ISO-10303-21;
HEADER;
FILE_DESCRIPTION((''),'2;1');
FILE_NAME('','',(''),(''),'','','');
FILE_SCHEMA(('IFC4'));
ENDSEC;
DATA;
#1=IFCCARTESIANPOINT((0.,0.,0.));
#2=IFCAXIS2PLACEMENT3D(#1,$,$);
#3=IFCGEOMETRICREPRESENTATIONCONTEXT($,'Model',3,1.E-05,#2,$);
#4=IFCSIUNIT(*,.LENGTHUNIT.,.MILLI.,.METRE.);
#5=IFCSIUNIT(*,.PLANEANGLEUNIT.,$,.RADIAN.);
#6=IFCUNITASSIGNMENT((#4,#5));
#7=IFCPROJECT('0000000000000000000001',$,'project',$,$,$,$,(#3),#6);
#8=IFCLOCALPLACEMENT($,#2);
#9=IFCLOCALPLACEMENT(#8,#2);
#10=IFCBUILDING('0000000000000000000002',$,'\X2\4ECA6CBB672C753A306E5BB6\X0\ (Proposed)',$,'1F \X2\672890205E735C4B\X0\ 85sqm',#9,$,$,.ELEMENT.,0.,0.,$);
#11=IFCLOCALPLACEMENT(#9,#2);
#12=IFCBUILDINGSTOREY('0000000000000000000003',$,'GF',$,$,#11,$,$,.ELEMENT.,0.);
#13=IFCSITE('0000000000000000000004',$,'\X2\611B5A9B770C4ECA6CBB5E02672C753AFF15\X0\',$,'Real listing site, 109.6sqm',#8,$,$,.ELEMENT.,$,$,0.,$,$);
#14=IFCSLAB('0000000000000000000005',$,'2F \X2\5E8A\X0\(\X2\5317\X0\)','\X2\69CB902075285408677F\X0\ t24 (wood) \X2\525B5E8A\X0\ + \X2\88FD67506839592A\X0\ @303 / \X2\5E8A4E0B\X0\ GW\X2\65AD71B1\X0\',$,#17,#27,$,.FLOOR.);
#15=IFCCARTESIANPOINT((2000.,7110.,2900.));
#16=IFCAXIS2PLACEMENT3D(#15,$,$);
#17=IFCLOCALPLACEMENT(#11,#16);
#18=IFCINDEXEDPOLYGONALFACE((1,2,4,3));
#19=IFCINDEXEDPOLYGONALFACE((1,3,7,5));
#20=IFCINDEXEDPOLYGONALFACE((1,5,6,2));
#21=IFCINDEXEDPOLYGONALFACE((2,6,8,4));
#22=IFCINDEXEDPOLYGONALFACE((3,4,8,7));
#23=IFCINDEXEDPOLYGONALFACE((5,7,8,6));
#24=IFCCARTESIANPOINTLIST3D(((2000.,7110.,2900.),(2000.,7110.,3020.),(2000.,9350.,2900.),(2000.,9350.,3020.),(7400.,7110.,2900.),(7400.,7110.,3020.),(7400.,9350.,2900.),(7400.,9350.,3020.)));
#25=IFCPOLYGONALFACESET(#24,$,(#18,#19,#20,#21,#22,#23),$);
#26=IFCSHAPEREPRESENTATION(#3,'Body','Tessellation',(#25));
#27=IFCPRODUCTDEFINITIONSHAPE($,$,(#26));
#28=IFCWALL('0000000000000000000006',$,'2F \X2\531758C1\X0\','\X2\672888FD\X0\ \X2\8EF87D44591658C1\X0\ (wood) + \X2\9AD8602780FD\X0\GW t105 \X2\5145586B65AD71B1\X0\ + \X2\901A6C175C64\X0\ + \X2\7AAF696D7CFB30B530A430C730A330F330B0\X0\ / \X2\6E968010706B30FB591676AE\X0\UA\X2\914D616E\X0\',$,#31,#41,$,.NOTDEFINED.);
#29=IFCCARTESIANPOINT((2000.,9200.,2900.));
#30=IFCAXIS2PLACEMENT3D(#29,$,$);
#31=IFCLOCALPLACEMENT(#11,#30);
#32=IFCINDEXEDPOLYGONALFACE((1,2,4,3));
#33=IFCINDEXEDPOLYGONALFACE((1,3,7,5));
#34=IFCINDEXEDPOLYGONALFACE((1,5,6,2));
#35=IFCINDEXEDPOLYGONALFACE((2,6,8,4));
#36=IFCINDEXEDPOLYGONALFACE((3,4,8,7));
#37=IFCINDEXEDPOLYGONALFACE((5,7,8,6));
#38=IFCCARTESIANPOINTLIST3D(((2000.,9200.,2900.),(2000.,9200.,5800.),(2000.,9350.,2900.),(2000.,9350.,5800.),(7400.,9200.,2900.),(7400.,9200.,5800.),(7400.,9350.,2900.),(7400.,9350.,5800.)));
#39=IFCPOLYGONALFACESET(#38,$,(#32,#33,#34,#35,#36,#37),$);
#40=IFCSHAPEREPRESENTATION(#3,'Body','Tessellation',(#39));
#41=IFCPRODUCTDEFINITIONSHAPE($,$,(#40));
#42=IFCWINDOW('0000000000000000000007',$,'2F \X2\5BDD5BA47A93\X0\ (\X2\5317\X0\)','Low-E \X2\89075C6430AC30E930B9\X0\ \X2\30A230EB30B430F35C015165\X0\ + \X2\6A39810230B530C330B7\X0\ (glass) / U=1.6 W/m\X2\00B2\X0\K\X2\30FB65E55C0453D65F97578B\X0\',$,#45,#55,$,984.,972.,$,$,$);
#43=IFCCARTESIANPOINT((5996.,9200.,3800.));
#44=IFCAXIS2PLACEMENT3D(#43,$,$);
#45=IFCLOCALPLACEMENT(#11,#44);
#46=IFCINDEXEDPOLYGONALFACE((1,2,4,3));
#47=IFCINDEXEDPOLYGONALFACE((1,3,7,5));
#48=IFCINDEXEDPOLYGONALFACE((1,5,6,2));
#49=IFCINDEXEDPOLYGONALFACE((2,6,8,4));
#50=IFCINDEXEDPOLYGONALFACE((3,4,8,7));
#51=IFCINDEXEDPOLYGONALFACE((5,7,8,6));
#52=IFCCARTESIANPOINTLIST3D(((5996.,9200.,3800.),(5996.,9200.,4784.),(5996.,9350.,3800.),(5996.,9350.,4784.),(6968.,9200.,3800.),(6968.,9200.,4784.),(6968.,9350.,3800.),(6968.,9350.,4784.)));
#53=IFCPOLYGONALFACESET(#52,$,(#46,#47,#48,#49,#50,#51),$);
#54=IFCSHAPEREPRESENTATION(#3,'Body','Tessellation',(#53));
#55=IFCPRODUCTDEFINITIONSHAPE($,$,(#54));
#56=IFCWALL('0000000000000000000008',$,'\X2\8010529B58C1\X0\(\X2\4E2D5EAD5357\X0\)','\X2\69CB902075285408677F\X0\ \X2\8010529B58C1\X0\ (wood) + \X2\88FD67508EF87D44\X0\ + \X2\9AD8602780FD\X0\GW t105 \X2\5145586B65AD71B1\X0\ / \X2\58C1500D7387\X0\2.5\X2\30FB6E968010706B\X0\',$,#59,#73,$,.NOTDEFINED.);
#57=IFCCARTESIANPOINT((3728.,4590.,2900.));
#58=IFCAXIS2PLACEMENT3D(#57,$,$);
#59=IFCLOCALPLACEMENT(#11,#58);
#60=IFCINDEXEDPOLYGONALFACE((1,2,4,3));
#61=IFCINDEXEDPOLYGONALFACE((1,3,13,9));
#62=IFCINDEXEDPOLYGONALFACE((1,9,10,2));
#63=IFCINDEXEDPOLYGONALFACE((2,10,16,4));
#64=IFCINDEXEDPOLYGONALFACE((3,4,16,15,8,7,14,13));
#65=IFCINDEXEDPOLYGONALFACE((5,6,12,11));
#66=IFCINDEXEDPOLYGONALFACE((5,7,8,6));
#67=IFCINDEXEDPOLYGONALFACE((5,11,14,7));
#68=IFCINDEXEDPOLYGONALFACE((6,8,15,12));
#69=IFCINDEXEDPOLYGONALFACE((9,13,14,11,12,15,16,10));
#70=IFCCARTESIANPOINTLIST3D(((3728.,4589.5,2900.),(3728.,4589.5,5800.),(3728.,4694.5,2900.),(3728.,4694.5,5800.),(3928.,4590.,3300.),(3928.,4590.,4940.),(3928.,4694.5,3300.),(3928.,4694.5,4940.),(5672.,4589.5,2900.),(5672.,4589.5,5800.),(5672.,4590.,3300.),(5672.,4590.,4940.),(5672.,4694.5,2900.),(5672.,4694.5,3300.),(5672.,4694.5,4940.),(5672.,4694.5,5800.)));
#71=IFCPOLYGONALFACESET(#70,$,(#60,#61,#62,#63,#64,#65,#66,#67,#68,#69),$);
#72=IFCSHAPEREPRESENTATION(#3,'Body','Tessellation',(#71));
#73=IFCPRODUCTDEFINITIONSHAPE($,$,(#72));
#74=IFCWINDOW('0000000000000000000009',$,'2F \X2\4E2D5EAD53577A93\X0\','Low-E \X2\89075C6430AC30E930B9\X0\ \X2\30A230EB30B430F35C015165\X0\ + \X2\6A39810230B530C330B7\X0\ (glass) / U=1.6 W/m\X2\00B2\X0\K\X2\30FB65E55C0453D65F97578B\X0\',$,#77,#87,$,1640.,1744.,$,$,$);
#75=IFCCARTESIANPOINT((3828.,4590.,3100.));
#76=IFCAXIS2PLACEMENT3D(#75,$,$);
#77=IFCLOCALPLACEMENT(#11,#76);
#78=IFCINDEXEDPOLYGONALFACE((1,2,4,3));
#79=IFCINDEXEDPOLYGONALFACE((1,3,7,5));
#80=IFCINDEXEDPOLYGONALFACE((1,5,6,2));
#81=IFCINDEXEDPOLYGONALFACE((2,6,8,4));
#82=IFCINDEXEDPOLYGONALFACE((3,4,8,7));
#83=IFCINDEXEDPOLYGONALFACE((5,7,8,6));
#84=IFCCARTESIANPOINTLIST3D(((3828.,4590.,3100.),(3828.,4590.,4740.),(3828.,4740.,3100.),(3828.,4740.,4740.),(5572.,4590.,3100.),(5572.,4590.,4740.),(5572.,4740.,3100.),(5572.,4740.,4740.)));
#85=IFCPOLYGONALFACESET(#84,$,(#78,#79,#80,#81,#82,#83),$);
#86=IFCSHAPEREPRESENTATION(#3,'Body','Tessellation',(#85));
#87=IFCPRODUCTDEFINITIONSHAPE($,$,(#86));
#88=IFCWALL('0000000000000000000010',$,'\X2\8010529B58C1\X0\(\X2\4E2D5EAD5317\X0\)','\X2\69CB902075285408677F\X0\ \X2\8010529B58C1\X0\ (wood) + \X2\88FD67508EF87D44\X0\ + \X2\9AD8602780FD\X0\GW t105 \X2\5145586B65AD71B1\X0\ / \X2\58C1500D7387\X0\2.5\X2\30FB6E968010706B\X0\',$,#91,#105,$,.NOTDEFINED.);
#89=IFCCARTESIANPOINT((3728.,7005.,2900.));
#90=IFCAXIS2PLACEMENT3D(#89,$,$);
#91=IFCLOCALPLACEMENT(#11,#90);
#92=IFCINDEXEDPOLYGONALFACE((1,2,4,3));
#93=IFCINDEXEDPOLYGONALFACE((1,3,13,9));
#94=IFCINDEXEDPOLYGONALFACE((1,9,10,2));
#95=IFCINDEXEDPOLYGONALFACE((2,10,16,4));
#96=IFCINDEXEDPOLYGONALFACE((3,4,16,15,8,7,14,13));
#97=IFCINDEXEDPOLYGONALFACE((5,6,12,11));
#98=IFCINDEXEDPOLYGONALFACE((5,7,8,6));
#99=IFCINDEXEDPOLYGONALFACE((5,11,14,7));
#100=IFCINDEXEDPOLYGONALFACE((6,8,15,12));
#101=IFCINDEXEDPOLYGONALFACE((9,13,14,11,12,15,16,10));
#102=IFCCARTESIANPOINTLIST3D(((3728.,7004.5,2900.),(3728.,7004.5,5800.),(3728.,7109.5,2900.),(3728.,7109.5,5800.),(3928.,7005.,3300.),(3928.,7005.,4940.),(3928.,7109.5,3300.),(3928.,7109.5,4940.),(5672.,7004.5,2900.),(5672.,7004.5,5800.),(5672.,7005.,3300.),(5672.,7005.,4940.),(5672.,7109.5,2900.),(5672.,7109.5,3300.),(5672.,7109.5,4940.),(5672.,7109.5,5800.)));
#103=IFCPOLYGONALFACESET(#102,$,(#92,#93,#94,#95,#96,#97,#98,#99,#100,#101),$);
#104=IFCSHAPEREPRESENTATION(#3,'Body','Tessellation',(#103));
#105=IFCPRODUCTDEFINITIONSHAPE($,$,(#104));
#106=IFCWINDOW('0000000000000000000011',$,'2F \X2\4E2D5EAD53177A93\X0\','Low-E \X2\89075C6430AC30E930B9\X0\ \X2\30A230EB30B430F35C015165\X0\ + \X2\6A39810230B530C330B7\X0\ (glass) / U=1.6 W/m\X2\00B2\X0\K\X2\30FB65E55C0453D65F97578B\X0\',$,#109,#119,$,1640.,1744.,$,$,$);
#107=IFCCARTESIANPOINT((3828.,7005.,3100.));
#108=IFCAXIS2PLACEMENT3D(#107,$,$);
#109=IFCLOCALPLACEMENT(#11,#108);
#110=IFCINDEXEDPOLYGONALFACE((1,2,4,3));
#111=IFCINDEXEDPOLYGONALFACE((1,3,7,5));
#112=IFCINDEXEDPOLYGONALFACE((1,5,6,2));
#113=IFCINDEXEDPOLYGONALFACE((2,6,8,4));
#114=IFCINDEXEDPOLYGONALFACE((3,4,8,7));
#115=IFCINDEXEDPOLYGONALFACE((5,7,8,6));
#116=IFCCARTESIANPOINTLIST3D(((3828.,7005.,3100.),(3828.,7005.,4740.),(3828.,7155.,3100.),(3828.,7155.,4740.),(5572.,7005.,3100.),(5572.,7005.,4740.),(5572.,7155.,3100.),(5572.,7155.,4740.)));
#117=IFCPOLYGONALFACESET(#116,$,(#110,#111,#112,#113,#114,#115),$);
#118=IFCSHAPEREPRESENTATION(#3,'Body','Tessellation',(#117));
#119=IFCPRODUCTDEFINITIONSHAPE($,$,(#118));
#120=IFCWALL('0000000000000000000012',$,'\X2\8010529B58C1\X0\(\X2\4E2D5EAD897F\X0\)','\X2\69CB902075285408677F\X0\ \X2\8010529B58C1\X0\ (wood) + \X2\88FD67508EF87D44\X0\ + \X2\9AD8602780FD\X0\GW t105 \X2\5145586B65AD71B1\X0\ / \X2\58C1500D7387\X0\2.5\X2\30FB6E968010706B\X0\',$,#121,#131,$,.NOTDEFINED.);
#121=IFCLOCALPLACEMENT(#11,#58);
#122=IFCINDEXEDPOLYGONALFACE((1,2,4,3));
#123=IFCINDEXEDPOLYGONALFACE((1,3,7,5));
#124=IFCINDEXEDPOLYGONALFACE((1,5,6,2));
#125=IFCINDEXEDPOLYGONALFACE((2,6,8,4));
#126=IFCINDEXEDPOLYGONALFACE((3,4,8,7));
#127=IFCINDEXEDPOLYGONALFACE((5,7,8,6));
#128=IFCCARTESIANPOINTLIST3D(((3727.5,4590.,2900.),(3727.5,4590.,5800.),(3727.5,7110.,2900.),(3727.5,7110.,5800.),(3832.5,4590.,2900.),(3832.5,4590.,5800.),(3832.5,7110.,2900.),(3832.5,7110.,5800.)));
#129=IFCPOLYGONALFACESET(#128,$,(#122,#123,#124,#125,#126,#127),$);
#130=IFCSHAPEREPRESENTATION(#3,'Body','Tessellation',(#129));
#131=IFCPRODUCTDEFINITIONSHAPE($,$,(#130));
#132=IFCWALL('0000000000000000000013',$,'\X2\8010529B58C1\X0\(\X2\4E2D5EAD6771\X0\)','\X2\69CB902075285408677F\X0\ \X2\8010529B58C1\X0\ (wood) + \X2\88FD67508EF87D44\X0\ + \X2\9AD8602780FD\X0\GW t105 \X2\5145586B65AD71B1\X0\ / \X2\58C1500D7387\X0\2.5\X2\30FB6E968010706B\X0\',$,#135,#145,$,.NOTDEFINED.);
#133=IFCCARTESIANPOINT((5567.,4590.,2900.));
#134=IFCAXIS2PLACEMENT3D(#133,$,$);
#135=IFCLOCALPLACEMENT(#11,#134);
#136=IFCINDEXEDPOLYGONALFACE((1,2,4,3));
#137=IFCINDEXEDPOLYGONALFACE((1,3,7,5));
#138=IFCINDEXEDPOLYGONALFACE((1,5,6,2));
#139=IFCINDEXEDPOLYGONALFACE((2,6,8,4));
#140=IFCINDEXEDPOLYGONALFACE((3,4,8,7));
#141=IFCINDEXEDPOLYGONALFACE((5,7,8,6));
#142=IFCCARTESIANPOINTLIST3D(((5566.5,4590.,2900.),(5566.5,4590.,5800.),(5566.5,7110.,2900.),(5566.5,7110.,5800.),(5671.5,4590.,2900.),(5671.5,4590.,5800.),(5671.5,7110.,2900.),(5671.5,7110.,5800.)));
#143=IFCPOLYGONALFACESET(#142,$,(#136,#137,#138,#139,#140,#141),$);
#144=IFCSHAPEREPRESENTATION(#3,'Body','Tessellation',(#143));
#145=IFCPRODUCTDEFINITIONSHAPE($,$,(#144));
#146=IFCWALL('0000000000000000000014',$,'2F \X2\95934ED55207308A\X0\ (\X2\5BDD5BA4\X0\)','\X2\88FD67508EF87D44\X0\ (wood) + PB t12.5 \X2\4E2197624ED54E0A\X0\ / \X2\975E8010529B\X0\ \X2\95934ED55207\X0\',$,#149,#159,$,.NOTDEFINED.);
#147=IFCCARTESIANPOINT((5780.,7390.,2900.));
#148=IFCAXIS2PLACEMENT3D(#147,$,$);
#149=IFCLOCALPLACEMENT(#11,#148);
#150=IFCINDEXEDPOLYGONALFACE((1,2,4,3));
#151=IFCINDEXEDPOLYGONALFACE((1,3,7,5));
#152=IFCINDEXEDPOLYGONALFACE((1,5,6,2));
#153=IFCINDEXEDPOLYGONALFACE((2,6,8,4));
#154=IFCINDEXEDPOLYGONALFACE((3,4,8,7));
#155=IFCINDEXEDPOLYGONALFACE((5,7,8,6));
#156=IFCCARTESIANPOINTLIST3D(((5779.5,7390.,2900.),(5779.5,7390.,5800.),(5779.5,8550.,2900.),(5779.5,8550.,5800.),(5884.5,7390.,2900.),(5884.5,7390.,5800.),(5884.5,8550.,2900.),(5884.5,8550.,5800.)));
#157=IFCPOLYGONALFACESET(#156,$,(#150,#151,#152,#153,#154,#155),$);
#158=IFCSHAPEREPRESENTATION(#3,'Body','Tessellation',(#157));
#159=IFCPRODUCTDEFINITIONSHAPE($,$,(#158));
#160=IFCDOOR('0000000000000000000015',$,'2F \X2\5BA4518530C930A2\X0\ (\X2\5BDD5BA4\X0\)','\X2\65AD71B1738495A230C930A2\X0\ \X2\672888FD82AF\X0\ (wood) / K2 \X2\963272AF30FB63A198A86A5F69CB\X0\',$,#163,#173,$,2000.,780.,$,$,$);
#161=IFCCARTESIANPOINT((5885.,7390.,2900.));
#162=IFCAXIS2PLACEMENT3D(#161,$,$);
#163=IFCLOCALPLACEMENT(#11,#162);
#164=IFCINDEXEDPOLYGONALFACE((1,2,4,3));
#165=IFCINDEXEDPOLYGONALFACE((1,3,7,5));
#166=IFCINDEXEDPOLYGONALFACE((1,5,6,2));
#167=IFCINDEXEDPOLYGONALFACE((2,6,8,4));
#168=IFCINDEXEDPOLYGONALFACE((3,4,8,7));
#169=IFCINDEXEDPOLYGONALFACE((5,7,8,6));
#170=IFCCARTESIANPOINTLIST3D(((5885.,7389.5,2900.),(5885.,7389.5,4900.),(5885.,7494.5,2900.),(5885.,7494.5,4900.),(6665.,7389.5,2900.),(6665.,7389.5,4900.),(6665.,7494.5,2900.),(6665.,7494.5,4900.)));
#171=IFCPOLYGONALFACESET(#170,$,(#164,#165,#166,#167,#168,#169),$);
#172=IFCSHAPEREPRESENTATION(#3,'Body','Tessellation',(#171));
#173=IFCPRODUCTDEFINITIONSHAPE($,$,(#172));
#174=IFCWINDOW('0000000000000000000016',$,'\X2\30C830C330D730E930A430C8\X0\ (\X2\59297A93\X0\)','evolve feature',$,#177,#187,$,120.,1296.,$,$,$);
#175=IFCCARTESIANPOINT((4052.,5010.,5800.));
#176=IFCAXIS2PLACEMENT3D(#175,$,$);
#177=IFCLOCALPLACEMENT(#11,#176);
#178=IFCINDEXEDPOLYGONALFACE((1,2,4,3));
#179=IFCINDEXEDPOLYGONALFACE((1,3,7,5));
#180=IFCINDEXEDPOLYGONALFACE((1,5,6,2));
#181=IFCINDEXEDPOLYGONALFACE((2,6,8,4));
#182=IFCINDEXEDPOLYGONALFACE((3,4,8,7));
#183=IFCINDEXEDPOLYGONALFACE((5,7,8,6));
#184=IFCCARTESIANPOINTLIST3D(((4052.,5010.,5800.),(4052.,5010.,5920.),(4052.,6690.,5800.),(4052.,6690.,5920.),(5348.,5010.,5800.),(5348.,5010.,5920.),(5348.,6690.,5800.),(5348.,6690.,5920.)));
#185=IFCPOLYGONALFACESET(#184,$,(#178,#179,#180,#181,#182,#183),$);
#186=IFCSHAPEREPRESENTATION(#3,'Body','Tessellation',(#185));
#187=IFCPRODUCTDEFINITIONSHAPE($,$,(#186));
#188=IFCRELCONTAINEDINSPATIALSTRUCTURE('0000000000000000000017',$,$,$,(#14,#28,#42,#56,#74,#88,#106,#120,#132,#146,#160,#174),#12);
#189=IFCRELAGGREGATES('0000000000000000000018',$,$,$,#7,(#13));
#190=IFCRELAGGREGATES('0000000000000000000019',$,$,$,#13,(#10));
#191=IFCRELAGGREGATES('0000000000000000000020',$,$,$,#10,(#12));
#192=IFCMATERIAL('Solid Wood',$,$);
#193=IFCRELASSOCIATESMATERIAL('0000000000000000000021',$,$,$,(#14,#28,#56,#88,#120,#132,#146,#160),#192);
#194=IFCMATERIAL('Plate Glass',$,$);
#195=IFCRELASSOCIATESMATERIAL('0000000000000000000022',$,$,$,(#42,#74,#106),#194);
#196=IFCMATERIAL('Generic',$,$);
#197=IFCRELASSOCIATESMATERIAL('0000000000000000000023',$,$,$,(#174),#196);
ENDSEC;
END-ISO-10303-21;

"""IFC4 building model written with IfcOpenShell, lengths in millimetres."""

from ifc_helpers import new_model, si_unit, frame, frame_2d, origin, place, context, project, spatial, rectangle, extrude, material, element, fill, save


model = new_model("IFC4")

# Units and contexts
model_context = context("Model", 3, precision=1e-05, world=origin())
ifc_project = project(units=[si_unit("LENGTHUNIT", "METRE", prefix="MILLI"), si_unit("PLANEANGLEUNIT", "RADIAN")], contexts=[model_context])

# Site, building, storey
site_placement = place(None, origin())
site = spatial("IfcSite", under=ifc_project, at=site_placement, Name="愛媛県今治市本町５", ObjectType="Real listing site, 109.6sqm", CompositionType="ELEMENT", RefElevation=0.0)
building_placement = place(site_placement, origin())
building = spatial("IfcBuilding", under=site, at=building_placement, Name="今治本町の家 (Proposed)", ObjectType="1F 木造平屋 85sqm", CompositionType="ELEMENT", ElevationOfRefHeight=0.0, ElevationOfTerrain=0.0)
storey_placement = place(building_placement, origin())
storey = spatial("IfcBuildingStorey", under=building, at=storey_placement, Name="GF", CompositionType="ELEMENT", Elevation=0.0)

# Slab
ifc_material_1 = material(Name="Solid Wood")
slab_placement = place(storey_placement, frame((2000.0, 7110.0, 2900.0)))
element("IfcSlab", 1, at=slab_placement, inside=storey, material=ifc_material_1, Name="2F 床(北)", Description="構造用合板 t24 (wood) 剛床 + 製材根太 @303 / 床下 GW断熱", PredefinedType="FLOOR", context=model_context, shape_type="SweptSolid", body=[
    extrude(rectangle(XDim=5400.0, YDim=2240.0, at=frame_2d((2700.0, 1120.0))), frame((2000.0, 7110.0, 2900.0)), (0.0, 0.0, 1.0), 120.0),
])

# Walls, openings, windows
wall_1_placement = place(storey_placement, frame((2000.0, 9200.0, 2900.0)))
wall_1 = element("IfcWall", 2, at=wall_1_placement, inside=storey, material=ifc_material_1, Name="2F 北壁", Description="木製 軸組外壁 (wood) + 高性能GW t105 充填断熱 + 通気層 + 窯業系サイディング / 準耐火・外皮UA配慮", PredefinedType="NOTDEFINED", context=model_context, shape_type="SweptSolid", body=[
    extrude(rectangle(XDim=5400.0, YDim=150.0, at=frame_2d((2700.0, 75.0))), frame((2000.0, 9200.0, 2900.0)), (0.0, 0.0, 1.0), 2900.0),
])
opening_1_placement = place(storey_placement, frame((5996.0, 9200.0, 3800.0)))
opening_1 = element("IfcOpeningElement", 3, at=opening_1_placement, cuts=wall_1, PredefinedType="NOTDEFINED", context=model_context, shape_type="SweptSolid", body=[
    extrude(rectangle(XDim=972.0, YDim=150.0, at=frame_2d((486.0, 75.0))), frame((5996.0, 9200.0, 3800.0)), (0.0, 0.0, 1.0), 984.0),
])
ifc_material_2 = material(Name="Plate Glass")
window_1_placement = place(storey_placement, frame((5996.0, 9200.0, 3800.0)))
window_1 = element("IfcWindow", 4, at=window_1_placement, inside=storey, material=ifc_material_2, Name="2F 寝室窓 (北)", Description="Low-E 複層ガラス アルゴン封入 + 樹脂サッシ (glass) / U=1.6 W/m²K・日射取得型", OverallHeight=984.0, OverallWidth=972.0, context=model_context, shape_type="SweptSolid", body=[
    extrude(rectangle(XDim=972.0, YDim=150.0, at=frame_2d((486.0, 75.0))), frame((5996.0, 9200.0, 3800.0)), (0.0, 0.0, 1.0), 984.0),
])
fill(opening_1, window_1)
wall_2_placement = place(storey_placement, frame((3728.0, 4590.0, 2900.0)))
wall_2 = element("IfcWall", 5, at=wall_2_placement, inside=storey, material=ifc_material_1, Name="耐力壁(中庭南)", Description="構造用合板 耐力壁 (wood) + 製材軸組 + 高性能GW t105 充填断熱 / 壁倍率2.5・準耐火", PredefinedType="NOTDEFINED", context=model_context, shape_type="SweptSolid", body=[
    extrude(rectangle(XDim=1944.0, YDim=105.0, at=frame_2d((972.0, 52.0))), frame((3728.0, 4590.0, 2900.0)), (0.0, 0.0, 1.0), 2900.0),
])
opening_2_placement = place(storey_placement, frame((3828.0, 4590.0, 3100.0)))
opening_2 = element("IfcOpeningElement", 6, at=opening_2_placement, cuts=wall_2, PredefinedType="NOTDEFINED", context=model_context, shape_type="SweptSolid", body=[
    extrude(rectangle(XDim=1744.0, YDim=150.0, at=frame_2d((872.0, 75.0))), frame((3828.0, 4590.0, 3100.0)), (0.0, 0.0, 1.0), 1640.0),
])
window_2_placement = place(storey_placement, frame((3828.0, 4590.0, 3100.0)))
window_2 = element("IfcWindow", 7, at=window_2_placement, inside=storey, material=ifc_material_2, Name="2F 中庭南窓", Description="Low-E 複層ガラス アルゴン封入 + 樹脂サッシ (glass) / U=1.6 W/m²K・日射取得型", OverallHeight=1640.0, OverallWidth=1744.0, context=model_context, shape_type="SweptSolid", body=[
    extrude(rectangle(XDim=1744.0, YDim=150.0, at=frame_2d((872.0, 75.0))), frame((3828.0, 4590.0, 3100.0)), (0.0, 0.0, 1.0), 1640.0),
])
fill(opening_2, window_2)
wall_3_placement = place(storey_placement, frame((3728.0, 7005.0, 2900.0)))
wall_3 = element("IfcWall", 8, at=wall_3_placement, inside=storey, material=ifc_material_1, Name="耐力壁(中庭北)", Description="構造用合板 耐力壁 (wood) + 製材軸組 + 高性能GW t105 充填断熱 / 壁倍率2.5・準耐火", PredefinedType="NOTDEFINED", context=model_context, shape_type="SweptSolid", body=[
    extrude(rectangle(XDim=1944.0, YDim=105.0, at=frame_2d((972.0, 52.0))), frame((3728.0, 7005.0, 2900.0)), (0.0, 0.0, 1.0), 2900.0),
])
opening_3_placement = place(storey_placement, frame((3828.0, 7005.0, 3100.0)))
opening_3 = element("IfcOpeningElement", 9, at=opening_3_placement, cuts=wall_3, PredefinedType="NOTDEFINED", context=model_context, shape_type="SweptSolid", body=[
    extrude(rectangle(XDim=1744.0, YDim=150.0, at=frame_2d((872.0, 75.0))), frame((3828.0, 7005.0, 3100.0)), (0.0, 0.0, 1.0), 1640.0),
])
window_3_placement = place(storey_placement, frame((3828.0, 7005.0, 3100.0)))
window_3 = element("IfcWindow", 10, at=window_3_placement, inside=storey, material=ifc_material_2, Name="2F 中庭北窓", Description="Low-E 複層ガラス アルゴン封入 + 樹脂サッシ (glass) / U=1.6 W/m²K・日射取得型", OverallHeight=1640.0, OverallWidth=1744.0, context=model_context, shape_type="SweptSolid", body=[
    extrude(rectangle(XDim=1744.0, YDim=150.0, at=frame_2d((872.0, 75.0))), frame((3828.0, 7005.0, 3100.0)), (0.0, 0.0, 1.0), 1640.0),
])
fill(opening_3, window_3)

# Walls
wall_4_placement = place(storey_placement, frame((3728.0, 4590.0, 2900.0)))
element("IfcWall", 11, at=wall_4_placement, inside=storey, material=ifc_material_1, Name="耐力壁(中庭西)", Description="構造用合板 耐力壁 (wood) + 製材軸組 + 高性能GW t105 充填断熱 / 壁倍率2.5・準耐火", PredefinedType="NOTDEFINED", context=model_context, shape_type="SweptSolid", body=[
    extrude(rectangle(XDim=105.0, YDim=2520.0, at=frame_2d((52.0, 1260.0))), frame((3728.0, 4590.0, 2900.0)), (0.0, 0.0, 1.0), 2900.0),
])
wall_5_placement = place(storey_placement, frame((5567.0, 4590.0, 2900.0)))
element("IfcWall", 12, at=wall_5_placement, inside=storey, material=ifc_material_1, Name="耐力壁(中庭東)", Description="構造用合板 耐力壁 (wood) + 製材軸組 + 高性能GW t105 充填断熱 / 壁倍率2.5・準耐火", PredefinedType="NOTDEFINED", context=model_context, shape_type="SweptSolid", body=[
    extrude(rectangle(XDim=105.0, YDim=2520.0, at=frame_2d((52.0, 1260.0))), frame((5567.0, 4590.0, 2900.0)), (0.0, 0.0, 1.0), 2900.0),
])
wall_6_placement = place(storey_placement, frame((5780.0, 7390.0, 2900.0)))
element("IfcWall", 13, at=wall_6_placement, inside=storey, material=ifc_material_1, Name="2F 間仕切り (寝室)", Description="製材軸組 (wood) + PB t12.5 両面仕上 / 非耐力 間仕切", PredefinedType="NOTDEFINED", context=model_context, shape_type="SweptSolid", body=[
    extrude(rectangle(XDim=105.0, YDim=1160.0, at=frame_2d((52.0, 580.0))), frame((5780.0, 7390.0, 2900.0)), (0.0, 0.0, 1.0), 2900.0),
])

# Door
door_placement = place(storey_placement, frame((5885.0, 7390.0, 2900.0)))
element("IfcDoor", 14, at=door_placement, inside=storey, material=ifc_material_1, Name="2F 室内ドア (寝室)", Description="断熱玄関ドア 木製芯 (wood) / K2 防犯・採風機構", OverallHeight=2000.0, OverallWidth=780.0, context=model_context, shape_type="SweptSolid", body=[
    extrude(rectangle(XDim=780.0, YDim=105.0, at=frame_2d((390.0, 52.0))), frame((5885.0, 7390.0, 2900.0)), (0.0, 0.0, 1.0), 2000.0),
])

# Window
ifc_material_3 = material(Name="Generic")
window_4_placement = place(storey_placement, frame((4052.0, 5010.0, 5800.0)))
element("IfcWindow", 15, at=window_4_placement, inside=storey, material=ifc_material_3, Name="トップライト (天窓)", Description="evolve feature", OverallHeight=120.0, OverallWidth=1296.0, context=model_context, shape_type="SweptSolid", body=[
    extrude(rectangle(XDim=1296.0, YDim=1680.0, at=frame_2d((648.0, 840.0))), frame((4052.0, 5010.0, 5800.0)), (0.0, 0.0, 1.0), 120.0),
])

save(model, "model.ifc")
